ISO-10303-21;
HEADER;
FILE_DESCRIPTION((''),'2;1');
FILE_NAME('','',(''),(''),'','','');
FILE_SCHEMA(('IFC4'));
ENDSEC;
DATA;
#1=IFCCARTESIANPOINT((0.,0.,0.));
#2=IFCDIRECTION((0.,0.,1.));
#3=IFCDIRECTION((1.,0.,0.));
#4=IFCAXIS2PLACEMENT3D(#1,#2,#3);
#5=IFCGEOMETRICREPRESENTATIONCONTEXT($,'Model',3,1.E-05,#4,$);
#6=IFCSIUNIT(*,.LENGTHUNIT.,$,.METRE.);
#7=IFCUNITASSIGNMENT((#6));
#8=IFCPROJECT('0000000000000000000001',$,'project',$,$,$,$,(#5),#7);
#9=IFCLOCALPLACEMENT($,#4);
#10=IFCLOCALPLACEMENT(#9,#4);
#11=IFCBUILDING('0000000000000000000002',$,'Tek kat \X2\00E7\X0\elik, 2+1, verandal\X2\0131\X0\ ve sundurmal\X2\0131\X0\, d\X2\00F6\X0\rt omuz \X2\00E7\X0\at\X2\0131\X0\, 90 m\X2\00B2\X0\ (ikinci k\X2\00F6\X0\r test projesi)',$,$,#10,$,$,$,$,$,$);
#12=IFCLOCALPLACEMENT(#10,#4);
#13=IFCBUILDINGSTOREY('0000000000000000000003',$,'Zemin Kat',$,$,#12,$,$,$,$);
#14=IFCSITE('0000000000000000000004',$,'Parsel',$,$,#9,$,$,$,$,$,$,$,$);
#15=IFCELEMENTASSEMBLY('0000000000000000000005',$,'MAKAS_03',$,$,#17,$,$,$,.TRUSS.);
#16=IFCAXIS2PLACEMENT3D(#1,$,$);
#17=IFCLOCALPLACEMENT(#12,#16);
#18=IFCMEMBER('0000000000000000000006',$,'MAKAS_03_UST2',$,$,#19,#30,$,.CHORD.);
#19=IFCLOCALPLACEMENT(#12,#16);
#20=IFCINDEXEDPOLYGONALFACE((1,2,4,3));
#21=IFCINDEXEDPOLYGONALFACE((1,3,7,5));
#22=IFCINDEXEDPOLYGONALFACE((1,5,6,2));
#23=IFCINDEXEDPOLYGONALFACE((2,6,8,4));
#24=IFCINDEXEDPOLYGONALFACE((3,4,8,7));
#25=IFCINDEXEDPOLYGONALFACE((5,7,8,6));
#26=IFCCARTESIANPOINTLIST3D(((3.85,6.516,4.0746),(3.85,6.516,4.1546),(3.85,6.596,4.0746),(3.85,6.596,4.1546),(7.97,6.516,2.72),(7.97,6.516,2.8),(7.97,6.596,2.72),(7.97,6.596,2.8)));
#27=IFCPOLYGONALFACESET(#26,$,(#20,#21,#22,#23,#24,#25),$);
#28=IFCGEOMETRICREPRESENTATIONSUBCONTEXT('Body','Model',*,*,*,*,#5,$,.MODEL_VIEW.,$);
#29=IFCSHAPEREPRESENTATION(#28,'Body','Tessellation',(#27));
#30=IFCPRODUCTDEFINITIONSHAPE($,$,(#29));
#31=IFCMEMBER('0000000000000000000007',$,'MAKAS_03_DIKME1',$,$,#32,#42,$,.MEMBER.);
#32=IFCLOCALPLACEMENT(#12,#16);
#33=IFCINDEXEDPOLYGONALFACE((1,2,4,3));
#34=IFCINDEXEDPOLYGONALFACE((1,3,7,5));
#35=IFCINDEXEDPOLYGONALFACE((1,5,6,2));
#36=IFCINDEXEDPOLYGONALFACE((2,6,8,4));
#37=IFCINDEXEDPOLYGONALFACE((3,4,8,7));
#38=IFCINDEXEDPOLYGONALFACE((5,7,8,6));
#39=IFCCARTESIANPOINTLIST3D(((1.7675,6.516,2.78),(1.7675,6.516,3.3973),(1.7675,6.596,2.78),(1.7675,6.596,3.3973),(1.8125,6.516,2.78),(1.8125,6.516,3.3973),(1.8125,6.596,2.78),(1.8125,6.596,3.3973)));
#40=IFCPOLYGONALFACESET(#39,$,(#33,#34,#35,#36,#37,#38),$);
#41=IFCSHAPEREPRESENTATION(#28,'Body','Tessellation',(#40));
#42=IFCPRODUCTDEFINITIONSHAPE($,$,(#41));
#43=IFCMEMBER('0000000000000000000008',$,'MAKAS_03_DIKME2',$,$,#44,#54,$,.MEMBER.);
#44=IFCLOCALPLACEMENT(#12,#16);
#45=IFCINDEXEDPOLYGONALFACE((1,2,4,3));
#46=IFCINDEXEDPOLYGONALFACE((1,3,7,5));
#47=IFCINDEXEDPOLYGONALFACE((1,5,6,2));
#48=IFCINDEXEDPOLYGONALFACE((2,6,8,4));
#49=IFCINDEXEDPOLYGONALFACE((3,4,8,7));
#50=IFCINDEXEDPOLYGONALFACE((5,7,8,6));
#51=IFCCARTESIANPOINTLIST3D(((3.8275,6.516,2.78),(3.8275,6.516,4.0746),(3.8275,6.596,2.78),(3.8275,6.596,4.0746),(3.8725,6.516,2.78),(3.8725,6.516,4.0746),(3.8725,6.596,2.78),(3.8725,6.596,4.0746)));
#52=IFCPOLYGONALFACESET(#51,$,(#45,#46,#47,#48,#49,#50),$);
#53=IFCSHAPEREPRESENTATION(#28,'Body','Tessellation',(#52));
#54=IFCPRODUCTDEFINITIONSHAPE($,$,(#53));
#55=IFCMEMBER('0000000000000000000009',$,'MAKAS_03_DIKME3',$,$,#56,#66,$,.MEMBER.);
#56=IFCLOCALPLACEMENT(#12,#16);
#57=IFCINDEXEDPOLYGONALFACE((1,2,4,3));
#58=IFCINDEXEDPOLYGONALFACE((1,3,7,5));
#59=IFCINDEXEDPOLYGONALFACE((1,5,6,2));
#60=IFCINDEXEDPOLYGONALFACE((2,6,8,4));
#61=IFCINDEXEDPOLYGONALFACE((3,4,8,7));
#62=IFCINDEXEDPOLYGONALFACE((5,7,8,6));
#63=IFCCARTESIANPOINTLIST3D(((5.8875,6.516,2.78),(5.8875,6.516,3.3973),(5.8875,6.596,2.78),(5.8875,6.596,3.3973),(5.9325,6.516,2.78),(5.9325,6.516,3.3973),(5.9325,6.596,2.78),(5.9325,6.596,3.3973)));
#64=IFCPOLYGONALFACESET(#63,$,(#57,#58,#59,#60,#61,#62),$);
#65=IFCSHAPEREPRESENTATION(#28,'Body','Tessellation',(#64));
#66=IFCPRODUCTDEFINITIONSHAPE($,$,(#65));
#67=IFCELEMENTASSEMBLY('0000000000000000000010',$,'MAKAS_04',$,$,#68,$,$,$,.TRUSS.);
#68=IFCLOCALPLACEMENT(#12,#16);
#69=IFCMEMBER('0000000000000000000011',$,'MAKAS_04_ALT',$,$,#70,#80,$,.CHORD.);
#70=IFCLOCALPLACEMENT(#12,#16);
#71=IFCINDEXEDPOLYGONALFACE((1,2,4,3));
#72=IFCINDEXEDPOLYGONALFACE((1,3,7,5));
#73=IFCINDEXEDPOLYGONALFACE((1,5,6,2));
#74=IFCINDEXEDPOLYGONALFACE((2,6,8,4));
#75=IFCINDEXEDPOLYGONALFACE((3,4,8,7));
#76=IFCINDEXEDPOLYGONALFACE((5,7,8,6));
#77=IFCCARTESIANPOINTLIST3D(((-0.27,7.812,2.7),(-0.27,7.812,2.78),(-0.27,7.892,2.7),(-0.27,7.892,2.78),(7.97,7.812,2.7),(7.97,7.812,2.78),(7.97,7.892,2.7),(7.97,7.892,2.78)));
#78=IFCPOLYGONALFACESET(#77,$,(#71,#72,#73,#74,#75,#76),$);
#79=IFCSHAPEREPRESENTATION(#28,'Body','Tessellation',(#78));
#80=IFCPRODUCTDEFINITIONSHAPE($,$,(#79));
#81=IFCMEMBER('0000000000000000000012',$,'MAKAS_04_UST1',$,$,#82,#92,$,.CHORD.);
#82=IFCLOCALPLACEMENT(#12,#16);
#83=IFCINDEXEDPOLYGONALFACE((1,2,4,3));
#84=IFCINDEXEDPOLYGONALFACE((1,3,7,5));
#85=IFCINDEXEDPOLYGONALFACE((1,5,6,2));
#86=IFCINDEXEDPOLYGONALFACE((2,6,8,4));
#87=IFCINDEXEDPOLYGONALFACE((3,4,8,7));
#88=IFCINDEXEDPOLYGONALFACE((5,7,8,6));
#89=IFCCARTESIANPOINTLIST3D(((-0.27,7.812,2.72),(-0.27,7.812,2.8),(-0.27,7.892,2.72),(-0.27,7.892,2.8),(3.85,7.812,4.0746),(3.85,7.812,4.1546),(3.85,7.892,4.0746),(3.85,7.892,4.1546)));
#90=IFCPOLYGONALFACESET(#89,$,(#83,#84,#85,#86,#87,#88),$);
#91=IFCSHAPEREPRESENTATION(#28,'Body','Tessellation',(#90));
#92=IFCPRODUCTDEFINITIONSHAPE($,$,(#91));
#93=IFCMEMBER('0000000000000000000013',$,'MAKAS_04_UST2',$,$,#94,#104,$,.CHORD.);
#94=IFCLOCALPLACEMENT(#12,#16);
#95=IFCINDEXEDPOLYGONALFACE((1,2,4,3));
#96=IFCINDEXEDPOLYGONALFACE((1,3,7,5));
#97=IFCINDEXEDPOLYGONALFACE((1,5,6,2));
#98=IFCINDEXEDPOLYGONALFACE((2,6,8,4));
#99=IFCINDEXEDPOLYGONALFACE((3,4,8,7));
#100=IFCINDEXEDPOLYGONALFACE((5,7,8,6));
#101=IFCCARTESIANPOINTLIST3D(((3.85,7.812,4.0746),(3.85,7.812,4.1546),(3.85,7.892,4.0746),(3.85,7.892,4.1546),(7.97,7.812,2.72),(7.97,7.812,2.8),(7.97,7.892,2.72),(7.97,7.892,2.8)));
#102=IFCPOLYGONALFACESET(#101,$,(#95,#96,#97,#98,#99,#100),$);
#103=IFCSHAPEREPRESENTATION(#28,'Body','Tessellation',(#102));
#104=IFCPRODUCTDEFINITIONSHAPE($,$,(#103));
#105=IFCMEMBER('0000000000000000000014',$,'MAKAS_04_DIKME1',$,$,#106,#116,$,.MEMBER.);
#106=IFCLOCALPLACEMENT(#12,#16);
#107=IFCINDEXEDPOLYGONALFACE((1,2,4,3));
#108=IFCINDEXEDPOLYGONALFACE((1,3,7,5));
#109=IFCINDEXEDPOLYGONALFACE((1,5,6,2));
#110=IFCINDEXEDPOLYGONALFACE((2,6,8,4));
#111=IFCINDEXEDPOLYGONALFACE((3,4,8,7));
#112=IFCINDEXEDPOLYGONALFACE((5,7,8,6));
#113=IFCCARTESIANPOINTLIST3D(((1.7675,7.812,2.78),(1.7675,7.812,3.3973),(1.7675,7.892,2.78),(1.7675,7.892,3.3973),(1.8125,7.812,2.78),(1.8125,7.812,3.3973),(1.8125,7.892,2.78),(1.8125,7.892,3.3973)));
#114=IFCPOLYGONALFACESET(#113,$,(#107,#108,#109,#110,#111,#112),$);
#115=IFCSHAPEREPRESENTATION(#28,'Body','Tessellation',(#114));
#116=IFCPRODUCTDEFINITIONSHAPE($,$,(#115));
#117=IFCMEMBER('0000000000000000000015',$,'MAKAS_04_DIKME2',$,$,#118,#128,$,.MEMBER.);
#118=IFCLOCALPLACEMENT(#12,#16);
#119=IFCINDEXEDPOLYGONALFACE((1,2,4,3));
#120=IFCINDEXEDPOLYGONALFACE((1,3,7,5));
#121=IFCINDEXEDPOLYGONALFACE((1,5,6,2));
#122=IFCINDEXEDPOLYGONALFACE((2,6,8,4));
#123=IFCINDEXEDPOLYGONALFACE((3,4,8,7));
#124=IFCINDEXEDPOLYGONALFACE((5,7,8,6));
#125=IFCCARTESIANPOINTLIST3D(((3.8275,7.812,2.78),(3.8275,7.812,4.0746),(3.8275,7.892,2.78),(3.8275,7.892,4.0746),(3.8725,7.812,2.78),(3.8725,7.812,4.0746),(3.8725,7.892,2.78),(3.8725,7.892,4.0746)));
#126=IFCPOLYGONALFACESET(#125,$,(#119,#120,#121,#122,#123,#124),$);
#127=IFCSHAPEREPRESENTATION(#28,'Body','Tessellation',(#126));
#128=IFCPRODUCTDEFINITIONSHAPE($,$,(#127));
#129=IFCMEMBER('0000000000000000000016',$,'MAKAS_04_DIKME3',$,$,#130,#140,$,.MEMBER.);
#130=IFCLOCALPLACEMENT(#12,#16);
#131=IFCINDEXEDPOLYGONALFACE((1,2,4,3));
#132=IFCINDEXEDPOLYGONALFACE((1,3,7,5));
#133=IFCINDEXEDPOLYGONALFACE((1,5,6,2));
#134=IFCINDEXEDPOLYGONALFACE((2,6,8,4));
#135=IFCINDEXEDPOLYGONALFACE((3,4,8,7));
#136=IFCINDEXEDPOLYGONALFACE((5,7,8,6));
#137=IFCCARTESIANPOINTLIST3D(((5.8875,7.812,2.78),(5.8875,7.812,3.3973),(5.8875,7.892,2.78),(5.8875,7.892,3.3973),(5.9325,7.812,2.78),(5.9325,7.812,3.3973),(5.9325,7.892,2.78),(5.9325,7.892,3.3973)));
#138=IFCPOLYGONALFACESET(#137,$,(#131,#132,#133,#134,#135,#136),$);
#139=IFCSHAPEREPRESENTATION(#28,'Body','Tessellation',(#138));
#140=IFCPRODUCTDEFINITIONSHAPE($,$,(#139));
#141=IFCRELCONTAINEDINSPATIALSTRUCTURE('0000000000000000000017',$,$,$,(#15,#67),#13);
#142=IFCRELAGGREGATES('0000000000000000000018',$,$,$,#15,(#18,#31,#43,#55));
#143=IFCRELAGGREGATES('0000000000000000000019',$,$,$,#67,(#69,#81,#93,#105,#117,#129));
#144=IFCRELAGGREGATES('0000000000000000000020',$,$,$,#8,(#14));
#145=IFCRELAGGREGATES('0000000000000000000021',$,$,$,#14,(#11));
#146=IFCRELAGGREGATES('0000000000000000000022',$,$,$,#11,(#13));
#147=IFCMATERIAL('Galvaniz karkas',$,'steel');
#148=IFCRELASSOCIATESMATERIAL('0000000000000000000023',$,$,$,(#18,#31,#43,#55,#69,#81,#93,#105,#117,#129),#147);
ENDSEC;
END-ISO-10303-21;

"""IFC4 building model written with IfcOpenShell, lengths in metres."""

from ifc_helpers import new_model, si_unit, frame, origin_with_axes, place, context, subcontext, project, spatial, line, indexed_curve, outline, extrude, material, element, aggregate, save


model = new_model("IFC4")

# Units and contexts
model_context = context("Model", 3, precision=1e-05, world=origin_with_axes())
body_context = subcontext(model_context, "Body", "Model", "MODEL_VIEW")
ifc_project = project(units=[si_unit("LENGTHUNIT", "METRE")], contexts=[model_context])

# Site, building, storey
site_placement = place(None, origin_with_axes())
site = spatial("IfcSite", under=ifc_project, at=site_placement, Name="Parsel")
building_placement = place(site_placement, origin_with_axes())
building = spatial("IfcBuilding", under=site, at=building_placement, Name="Tek kat çelik, 2+1, verandalı ve sundurmalı, dört omuz çatı, 90 m² (ikinci kör test projesi)")
storey_placement = place(building_placement, origin_with_axes())
storey = spatial("IfcBuildingStorey", under=building, at=storey_placement, Name="Zemin Kat")

# Element assemblies, members
ifc_material_1 = material(Name="Galvaniz karkas", Category="steel")
assembly_1_placement = place(storey_placement, origin_with_axes())
assembly_1 = element("IfcElementAssembly", 1, at=assembly_1_placement, inside=storey, Name="MAKAS_03", PredefinedType="TRUSS")
member_1_placement = place(assembly_1_placement, origin_with_axes())
member_1 = element("IfcMember", 2, at=member_1_placement, material=ifc_material_1, Name="MAKAS_03_UST2", PredefinedType="CHORD", context=body_context, shape_type="SweptSolid", body=[
    extrude(outline(indexed_curve([(3.85, 4.0746), (7.97, 2.72), (7.97, 2.8), (3.85, 4.1546)], segments=[line(1, 2, 3, 4, 1)])), frame((0.0, 6.596, 0.0), z_axis=(0.0, -1.0, 0.0), x_axis=(1.0, 0.0, 0.0)), (0.0, 0.0, 1.0), 0.08),
])
member_2_placement = place(assembly_1_placement, origin_with_axes())
member_2 = element("IfcMember", 3, at=member_2_placement, material=ifc_material_1, Name="MAKAS_03_DIKME1", PredefinedType="MEMBER", context=body_context, shape_type="SweptSolid", body=[
    extrude(outline(indexed_curve([(1.7675, 2.78), (1.8125, 2.78), (1.8125, 3.3973), (1.7675, 3.3973)], segments=[line(1, 2, 3, 4, 1)])), frame((0.0, 6.596, 0.0), z_axis=(0.0, -1.0, 0.0), x_axis=(1.0, 0.0, 0.0)), (0.0, 0.0, 1.0), 0.08),
])
member_3_placement = place(assembly_1_placement, origin_with_axes())
member_3 = element("IfcMember", 4, at=member_3_placement, material=ifc_material_1, Name="MAKAS_03_DIKME2", PredefinedType="MEMBER", context=body_context, shape_type="SweptSolid", body=[
    extrude(outline(indexed_curve([(3.8275, 2.78), (3.8725, 2.78), (3.8725, 4.0746), (3.8275, 4.0746)], segments=[line(1, 2, 3, 4, 1)])), frame((0.0, 6.596, 0.0), z_axis=(0.0, -1.0, 0.0), x_axis=(1.0, 0.0, 0.0)), (0.0, 0.0, 1.0), 0.08),
])
member_4_placement = place(assembly_1_placement, origin_with_axes())
member_4 = element("IfcMember", 5, at=member_4_placement, material=ifc_material_1, Name="MAKAS_03_DIKME3", PredefinedType="MEMBER", context=body_context, shape_type="SweptSolid", body=[
    extrude(outline(indexed_curve([(5.8875, 2.78), (5.9325, 2.78), (5.9325, 3.3973), (5.8875, 3.3973)], segments=[line(1, 2, 3, 4, 1)])), frame((0.0, 6.596, 0.0), z_axis=(0.0, -1.0, 0.0), x_axis=(1.0, 0.0, 0.0)), (0.0, 0.0, 1.0), 0.08),
])
aggregate(assembly_1, [member_1, member_2, member_3, member_4])
assembly_2_placement = place(storey_placement, origin_with_axes())
assembly_2 = element("IfcElementAssembly", 6, at=assembly_2_placement, inside=storey, Name="MAKAS_04", PredefinedType="TRUSS")
member_5_placement = place(assembly_2_placement, origin_with_axes())
member_5 = element("IfcMember", 7, at=member_5_placement, material=ifc_material_1, Name="MAKAS_04_ALT", PredefinedType="CHORD", context=body_context, shape_type="SweptSolid", body=[
    extrude(outline(indexed_curve([(-0.27, 2.7), (7.97, 2.7), (7.97, 2.78), (-0.27, 2.78)], segments=[line(1, 2, 3, 4, 1)])), frame((0.0, 7.892, 0.0), z_axis=(0.0, -1.0, 0.0), x_axis=(1.0, 0.0, 0.0)), (0.0, 0.0, 1.0), 0.08),
])
member_6_placement = place(assembly_2_placement, origin_with_axes())
member_6 = element("IfcMember", 8, at=member_6_placement, material=ifc_material_1, Name="MAKAS_04_UST1", PredefinedType="CHORD", context=body_context, shape_type="SweptSolid", body=[
    extrude(outline(indexed_curve([(-0.27, 2.72), (3.85, 4.0746), (3.85, 4.1546), (-0.27, 2.8)], segments=[line(1, 2, 3, 4, 1)])), frame((0.0, 7.892, 0.0), z_axis=(0.0, -1.0, 0.0), x_axis=(1.0, 0.0, 0.0)), (0.0, 0.0, 1.0), 0.08),
])
member_7_placement = place(assembly_2_placement, origin_with_axes())
member_7 = element("IfcMember", 9, at=member_7_placement, material=ifc_material_1, Name="MAKAS_04_UST2", PredefinedType="CHORD", context=body_context, shape_type="SweptSolid", body=[
    extrude(outline(indexed_curve([(3.85, 4.0746), (7.97, 2.72), (7.97, 2.8), (3.85, 4.1546)], segments=[line(1, 2, 3, 4, 1)])), frame((0.0, 7.892, 0.0), z_axis=(0.0, -1.0, 0.0), x_axis=(1.0, 0.0, 0.0)), (0.0, 0.0, 1.0), 0.08),
])
member_8_placement = place(assembly_2_placement, origin_with_axes())
member_8 = element("IfcMember", 10, at=member_8_placement, material=ifc_material_1, Name="MAKAS_04_DIKME1", PredefinedType="MEMBER", context=body_context, shape_type="SweptSolid", body=[
    extrude(outline(indexed_curve([(1.7675, 2.78), (1.8125, 2.78), (1.8125, 3.3973), (1.7675, 3.3973)], segments=[line(1, 2, 3, 4, 1)])), frame((0.0, 7.892, 0.0), z_axis=(0.0, -1.0, 0.0), x_axis=(1.0, 0.0, 0.0)), (0.0, 0.0, 1.0), 0.08),
])
member_9_placement = place(assembly_2_placement, origin_with_axes())
member_9 = element("IfcMember", 11, at=member_9_placement, material=ifc_material_1, Name="MAKAS_04_DIKME2", PredefinedType="MEMBER", context=body_context, shape_type="SweptSolid", body=[
    extrude(outline(indexed_curve([(3.8275, 2.78), (3.8725, 2.78), (3.8725, 4.0746), (3.8275, 4.0746)], segments=[line(1, 2, 3, 4, 1)])), frame((0.0, 7.892, 0.0), z_axis=(0.0, -1.0, 0.0), x_axis=(1.0, 0.0, 0.0)), (0.0, 0.0, 1.0), 0.08),
])
member_10_placement = place(assembly_2_placement, origin_with_axes())
member_10 = element("IfcMember", 12, at=member_10_placement, material=ifc_material_1, Name="MAKAS_04_DIKME3", PredefinedType="MEMBER", context=body_context, shape_type="SweptSolid", body=[
    extrude(outline(indexed_curve([(5.8875, 2.78), (5.9325, 2.78), (5.9325, 3.3973), (5.8875, 3.3973)], segments=[line(1, 2, 3, 4, 1)])), frame((0.0, 7.892, 0.0), z_axis=(0.0, -1.0, 0.0), x_axis=(1.0, 0.0, 0.0)), (0.0, 0.0, 1.0), 0.08),
])
aggregate(assembly_2, [member_5, member_6, member_7, member_8, member_9, member_10])

save(model, "model.ifc")
